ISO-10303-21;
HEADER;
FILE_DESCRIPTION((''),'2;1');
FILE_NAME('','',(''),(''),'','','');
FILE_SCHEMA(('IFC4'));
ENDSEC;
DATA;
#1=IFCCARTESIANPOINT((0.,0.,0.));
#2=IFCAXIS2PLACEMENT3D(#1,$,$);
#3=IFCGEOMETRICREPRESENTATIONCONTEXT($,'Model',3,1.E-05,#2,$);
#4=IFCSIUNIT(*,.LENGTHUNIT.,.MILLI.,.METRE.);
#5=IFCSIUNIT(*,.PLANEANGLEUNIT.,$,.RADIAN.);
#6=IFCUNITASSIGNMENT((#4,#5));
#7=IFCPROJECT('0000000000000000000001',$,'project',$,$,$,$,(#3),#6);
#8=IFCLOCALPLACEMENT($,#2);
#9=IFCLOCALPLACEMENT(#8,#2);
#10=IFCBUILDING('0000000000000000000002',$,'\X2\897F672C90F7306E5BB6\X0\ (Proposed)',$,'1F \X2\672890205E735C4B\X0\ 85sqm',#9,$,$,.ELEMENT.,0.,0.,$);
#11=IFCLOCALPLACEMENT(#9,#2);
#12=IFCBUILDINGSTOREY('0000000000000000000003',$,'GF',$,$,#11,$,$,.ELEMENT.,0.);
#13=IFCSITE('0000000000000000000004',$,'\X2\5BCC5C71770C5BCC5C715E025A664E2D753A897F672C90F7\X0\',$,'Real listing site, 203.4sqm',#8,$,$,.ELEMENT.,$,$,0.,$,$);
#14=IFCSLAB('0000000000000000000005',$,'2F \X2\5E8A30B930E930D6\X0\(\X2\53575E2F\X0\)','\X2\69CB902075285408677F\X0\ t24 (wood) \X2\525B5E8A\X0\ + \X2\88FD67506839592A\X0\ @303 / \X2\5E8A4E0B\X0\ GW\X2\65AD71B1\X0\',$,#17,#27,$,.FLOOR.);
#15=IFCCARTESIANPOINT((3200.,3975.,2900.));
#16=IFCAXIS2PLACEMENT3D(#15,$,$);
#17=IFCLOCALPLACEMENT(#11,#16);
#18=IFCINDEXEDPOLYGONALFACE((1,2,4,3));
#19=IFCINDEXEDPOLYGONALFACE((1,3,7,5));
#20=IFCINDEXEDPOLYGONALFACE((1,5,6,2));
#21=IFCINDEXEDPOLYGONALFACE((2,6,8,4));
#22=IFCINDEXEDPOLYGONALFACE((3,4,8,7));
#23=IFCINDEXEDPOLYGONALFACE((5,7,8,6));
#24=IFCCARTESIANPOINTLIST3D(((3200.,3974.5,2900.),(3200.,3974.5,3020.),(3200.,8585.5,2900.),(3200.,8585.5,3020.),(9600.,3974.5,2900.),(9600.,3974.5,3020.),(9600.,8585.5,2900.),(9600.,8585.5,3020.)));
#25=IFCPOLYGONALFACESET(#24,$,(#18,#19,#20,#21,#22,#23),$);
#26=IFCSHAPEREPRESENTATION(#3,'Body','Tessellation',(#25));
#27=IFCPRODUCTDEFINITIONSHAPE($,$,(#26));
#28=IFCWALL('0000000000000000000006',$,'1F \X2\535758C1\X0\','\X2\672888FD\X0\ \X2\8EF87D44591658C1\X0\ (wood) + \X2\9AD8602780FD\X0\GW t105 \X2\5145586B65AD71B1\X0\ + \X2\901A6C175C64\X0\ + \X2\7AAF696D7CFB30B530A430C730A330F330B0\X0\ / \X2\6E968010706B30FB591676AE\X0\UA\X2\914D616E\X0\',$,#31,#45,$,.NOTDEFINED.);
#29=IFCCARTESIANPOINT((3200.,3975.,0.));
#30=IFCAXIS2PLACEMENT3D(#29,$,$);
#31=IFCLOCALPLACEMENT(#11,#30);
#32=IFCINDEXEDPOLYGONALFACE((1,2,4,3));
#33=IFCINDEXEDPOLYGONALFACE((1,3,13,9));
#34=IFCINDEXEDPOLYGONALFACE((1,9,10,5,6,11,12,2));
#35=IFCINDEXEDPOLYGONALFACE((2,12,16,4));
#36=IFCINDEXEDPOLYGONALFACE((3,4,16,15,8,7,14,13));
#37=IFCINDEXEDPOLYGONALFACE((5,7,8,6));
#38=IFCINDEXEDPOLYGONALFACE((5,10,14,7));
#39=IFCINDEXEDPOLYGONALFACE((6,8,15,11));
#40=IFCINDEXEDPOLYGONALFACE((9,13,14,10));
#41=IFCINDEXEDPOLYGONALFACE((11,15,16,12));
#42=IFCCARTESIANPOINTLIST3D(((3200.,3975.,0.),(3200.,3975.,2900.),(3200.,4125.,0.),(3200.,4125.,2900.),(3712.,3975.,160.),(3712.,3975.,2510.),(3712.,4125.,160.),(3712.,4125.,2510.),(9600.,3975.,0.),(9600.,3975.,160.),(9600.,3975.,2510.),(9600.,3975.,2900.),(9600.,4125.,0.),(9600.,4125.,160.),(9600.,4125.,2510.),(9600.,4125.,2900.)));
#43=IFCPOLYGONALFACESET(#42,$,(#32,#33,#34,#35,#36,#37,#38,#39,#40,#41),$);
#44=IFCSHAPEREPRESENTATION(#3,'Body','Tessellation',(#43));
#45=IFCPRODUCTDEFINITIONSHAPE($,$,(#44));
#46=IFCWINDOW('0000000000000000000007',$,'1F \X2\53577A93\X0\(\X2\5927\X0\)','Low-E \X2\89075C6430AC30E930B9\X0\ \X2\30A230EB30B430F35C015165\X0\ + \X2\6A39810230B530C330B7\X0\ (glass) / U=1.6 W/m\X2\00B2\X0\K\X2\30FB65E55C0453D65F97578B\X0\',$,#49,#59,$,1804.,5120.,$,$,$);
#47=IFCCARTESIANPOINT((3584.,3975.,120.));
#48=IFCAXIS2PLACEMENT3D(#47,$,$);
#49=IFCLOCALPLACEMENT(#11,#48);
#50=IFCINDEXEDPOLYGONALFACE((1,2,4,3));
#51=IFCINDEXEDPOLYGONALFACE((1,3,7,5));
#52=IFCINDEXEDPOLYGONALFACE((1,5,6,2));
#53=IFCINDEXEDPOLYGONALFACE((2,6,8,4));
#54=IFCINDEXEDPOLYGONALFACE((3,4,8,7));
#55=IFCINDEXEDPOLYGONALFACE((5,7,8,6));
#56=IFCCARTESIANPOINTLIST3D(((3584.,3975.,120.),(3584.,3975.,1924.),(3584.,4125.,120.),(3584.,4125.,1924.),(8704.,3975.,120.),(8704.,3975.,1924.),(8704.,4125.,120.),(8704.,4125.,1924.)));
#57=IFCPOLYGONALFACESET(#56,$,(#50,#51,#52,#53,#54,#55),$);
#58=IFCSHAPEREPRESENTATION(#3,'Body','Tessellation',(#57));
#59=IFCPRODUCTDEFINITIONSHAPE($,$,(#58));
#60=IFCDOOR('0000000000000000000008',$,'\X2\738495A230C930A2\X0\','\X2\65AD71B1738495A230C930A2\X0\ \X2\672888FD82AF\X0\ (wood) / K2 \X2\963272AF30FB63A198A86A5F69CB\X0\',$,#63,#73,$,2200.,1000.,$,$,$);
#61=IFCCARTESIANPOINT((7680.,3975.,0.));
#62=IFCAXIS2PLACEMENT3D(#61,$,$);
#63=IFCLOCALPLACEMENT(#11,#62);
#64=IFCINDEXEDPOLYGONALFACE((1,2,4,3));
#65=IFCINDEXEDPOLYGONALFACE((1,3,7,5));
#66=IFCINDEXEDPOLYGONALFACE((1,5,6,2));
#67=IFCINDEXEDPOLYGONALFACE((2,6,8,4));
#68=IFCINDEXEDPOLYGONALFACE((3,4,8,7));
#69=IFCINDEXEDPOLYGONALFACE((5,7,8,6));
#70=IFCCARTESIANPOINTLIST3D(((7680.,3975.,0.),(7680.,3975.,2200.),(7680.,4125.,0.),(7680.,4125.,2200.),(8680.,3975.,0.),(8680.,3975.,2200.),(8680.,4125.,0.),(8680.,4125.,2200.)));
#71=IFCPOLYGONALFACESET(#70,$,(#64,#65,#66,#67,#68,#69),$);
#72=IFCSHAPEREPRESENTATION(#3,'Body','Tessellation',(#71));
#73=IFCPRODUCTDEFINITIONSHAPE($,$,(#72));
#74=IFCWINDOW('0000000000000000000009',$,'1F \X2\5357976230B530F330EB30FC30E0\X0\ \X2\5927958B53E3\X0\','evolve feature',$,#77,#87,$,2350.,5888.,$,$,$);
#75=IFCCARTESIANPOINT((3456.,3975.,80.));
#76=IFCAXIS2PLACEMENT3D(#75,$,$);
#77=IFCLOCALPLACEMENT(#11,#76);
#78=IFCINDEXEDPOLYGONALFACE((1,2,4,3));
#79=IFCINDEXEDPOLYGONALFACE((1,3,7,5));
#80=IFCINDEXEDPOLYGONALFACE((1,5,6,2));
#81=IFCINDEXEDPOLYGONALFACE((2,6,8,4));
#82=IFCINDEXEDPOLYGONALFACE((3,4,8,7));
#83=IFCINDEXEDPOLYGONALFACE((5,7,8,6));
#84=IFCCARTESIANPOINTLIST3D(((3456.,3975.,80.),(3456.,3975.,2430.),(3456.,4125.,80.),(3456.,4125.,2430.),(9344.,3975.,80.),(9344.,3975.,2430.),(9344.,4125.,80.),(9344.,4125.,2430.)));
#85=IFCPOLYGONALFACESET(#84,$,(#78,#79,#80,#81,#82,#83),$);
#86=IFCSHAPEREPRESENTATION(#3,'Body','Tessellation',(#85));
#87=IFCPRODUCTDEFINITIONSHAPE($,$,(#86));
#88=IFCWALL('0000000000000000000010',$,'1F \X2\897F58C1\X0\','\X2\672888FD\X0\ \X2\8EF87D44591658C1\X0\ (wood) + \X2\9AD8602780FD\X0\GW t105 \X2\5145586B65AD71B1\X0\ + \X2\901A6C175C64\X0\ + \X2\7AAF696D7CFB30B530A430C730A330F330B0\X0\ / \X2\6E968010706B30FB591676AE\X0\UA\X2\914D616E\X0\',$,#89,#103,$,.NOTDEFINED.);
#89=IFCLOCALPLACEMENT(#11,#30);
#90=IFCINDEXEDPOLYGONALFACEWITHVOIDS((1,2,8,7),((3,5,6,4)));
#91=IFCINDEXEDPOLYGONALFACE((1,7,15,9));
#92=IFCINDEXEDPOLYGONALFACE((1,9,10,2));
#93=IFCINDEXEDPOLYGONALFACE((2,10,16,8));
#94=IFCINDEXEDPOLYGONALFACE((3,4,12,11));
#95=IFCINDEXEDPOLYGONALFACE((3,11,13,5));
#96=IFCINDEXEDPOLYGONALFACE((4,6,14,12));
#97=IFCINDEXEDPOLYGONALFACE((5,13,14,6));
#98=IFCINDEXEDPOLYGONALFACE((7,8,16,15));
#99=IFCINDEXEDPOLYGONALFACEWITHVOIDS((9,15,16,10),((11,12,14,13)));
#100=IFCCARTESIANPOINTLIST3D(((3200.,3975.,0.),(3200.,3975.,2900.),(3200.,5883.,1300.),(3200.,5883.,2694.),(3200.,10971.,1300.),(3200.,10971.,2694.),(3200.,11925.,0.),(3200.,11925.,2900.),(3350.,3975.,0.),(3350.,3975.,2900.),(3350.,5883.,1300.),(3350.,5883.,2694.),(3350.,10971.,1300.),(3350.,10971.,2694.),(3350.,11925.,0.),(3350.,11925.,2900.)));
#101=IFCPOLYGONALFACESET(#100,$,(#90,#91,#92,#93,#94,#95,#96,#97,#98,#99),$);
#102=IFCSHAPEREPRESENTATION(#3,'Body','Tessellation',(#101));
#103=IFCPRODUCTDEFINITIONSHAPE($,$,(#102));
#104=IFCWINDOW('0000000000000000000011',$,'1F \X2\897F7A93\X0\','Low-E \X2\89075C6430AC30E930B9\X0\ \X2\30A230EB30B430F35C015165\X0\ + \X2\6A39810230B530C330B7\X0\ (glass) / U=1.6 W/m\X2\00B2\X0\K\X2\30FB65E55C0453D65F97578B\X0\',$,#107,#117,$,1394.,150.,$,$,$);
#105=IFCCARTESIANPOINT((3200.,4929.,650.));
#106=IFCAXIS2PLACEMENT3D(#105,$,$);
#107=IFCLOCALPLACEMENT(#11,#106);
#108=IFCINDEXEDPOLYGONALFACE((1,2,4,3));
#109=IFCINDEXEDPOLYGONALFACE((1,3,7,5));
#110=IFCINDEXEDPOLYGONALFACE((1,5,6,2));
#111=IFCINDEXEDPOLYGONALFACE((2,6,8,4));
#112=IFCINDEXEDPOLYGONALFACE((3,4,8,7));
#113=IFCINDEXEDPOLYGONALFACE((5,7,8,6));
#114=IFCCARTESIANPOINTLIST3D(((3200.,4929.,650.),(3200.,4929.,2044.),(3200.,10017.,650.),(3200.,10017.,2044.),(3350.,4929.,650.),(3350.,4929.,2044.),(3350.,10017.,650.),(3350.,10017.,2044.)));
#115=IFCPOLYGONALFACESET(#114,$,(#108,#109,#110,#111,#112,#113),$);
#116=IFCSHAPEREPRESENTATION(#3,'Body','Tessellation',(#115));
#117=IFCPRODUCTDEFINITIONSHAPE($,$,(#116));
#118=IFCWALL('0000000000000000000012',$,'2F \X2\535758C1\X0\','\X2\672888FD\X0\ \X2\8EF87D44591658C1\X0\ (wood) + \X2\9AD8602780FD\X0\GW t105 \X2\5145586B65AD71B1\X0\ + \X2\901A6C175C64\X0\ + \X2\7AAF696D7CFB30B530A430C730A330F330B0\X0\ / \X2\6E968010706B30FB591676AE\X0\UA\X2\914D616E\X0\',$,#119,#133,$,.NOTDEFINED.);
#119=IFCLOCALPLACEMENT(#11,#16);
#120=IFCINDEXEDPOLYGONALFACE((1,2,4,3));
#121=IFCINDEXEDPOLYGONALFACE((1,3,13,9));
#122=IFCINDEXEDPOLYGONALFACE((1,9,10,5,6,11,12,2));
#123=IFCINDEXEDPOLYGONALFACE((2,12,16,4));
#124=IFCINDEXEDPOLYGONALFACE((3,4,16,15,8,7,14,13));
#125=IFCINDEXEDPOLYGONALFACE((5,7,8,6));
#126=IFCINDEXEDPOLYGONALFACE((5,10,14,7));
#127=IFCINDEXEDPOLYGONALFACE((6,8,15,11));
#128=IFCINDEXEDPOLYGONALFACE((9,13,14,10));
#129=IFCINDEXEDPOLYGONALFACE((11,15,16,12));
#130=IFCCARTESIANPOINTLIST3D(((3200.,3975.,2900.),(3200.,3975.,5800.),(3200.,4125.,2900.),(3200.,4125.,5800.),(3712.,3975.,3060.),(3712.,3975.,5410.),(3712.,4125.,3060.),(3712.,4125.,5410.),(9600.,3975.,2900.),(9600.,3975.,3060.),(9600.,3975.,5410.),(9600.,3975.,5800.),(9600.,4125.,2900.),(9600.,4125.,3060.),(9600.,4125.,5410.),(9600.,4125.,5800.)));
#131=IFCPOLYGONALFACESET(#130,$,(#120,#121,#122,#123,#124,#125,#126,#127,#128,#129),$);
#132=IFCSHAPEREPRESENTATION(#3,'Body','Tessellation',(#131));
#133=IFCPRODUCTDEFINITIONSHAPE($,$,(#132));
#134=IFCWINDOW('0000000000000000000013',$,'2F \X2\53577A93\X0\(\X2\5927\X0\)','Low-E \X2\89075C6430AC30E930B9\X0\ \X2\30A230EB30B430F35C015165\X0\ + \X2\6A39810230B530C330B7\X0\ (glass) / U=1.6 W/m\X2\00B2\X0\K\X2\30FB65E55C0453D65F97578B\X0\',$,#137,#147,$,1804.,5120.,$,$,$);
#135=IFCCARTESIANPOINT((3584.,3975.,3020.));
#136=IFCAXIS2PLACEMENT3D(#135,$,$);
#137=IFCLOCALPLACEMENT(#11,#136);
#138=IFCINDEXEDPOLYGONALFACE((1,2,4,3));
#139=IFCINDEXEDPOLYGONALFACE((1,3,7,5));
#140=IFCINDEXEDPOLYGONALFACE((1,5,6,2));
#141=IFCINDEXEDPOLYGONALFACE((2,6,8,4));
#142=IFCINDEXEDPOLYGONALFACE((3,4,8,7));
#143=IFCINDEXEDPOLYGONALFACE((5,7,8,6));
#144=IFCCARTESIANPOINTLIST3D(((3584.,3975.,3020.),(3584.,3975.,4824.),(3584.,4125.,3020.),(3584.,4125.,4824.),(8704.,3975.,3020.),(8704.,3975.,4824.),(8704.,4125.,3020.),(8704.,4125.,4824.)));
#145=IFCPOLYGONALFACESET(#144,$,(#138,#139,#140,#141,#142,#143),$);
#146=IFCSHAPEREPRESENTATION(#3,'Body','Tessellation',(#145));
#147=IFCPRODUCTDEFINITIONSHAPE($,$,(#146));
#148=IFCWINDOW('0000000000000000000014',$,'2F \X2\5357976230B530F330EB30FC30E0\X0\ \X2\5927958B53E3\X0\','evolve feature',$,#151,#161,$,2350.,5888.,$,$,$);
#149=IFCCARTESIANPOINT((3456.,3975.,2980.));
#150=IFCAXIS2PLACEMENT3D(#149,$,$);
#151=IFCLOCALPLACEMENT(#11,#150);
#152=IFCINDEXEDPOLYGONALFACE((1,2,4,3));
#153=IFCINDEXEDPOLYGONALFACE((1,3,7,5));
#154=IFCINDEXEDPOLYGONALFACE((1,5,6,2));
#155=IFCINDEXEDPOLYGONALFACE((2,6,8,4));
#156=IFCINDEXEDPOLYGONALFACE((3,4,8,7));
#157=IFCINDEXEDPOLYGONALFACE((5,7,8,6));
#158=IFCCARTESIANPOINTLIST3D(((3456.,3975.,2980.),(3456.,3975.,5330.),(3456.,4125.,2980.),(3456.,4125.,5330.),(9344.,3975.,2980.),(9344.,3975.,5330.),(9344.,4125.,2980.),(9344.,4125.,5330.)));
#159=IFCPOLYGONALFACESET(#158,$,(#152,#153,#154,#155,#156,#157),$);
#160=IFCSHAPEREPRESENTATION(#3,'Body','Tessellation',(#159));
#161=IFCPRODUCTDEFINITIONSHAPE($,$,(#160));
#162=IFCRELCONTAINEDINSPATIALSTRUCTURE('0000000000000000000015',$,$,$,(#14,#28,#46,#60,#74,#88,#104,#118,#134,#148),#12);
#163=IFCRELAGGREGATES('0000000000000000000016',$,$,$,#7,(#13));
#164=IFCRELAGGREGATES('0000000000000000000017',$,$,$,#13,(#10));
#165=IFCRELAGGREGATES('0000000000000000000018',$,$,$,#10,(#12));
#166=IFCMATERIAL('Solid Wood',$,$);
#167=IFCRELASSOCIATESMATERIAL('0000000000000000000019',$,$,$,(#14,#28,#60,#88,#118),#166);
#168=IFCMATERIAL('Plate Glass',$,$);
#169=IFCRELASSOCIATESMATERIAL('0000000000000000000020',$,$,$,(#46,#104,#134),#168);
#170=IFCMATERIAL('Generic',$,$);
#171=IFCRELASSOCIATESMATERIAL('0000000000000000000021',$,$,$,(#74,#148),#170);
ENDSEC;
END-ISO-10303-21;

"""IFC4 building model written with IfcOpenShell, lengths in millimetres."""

from ifc_helpers import new_model, si_unit, frame, frame_2d, origin, place, context, project, spatial, rectangle, extrude, material, element, fill, save


model = new_model("IFC4")

# Units and contexts
model_context = context("Model", 3, precision=1e-05, world=origin())
ifc_project = project(units=[si_unit("LENGTHUNIT", "METRE", prefix="MILLI"), si_unit("PLANEANGLEUNIT", "RADIAN")], contexts=[model_context])

# Site, building, storey
site_placement = place(None, origin())
site = spatial("IfcSite", under=ifc_project, at=site_placement, Name="富山県富山市婦中町西本郷", ObjectType="Real listing site, 203.4sqm", CompositionType="ELEMENT", RefElevation=0.0)
building_placement = place(site_placement, origin())
building = spatial("IfcBuilding", under=site, at=building_placement, Name="西本郷の家 (Proposed)", ObjectType="1F 木造平屋 85sqm", CompositionType="ELEMENT", ElevationOfRefHeight=0.0, ElevationOfTerrain=0.0)
storey_placement = place(building_placement, origin())
storey = spatial("IfcBuildingStorey", under=building, at=storey_placement, Name="GF", CompositionType="ELEMENT", Elevation=0.0)

# Slab
ifc_material_1 = material(Name="Solid Wood")
slab_1_placement = place(storey_placement, frame((3200.0, 3975.0, 2900.0)))
element("IfcSlab", 1, at=slab_1_placement, inside=storey, material=ifc_material_1, Name="2F 床スラブ(南帯)", Description="構造用合板 t24 (wood) 剛床 + 製材根太 @303 / 床下 GW断熱", PredefinedType="FLOOR", context=model_context, shape_type="SweptSolid", body=[
    extrude(rectangle(XDim=6400.0, YDim=4611.0, at=frame_2d((3200.0, 2305.0))), frame((3200.0, 3975.0, 2900.0)), (0.0, 0.0, 1.0), 120.0),
])
ifc_material_2 = material(Name="Generic")

# Wall, openings, windows, door
wall_1_placement = place(storey_placement, frame((3200.0, 3975.0, 0.0)))
wall_1 = element("IfcWall", 2, at=wall_1_placement, inside=storey, material=ifc_material_1, Name="1F 南壁", Description="木製 軸組外壁 (wood) + 高性能GW t105 充填断熱 + 通気層 + 窯業系サイディング / 準耐火・外皮UA配慮", PredefinedType="NOTDEFINED", context=model_context, shape_type="SweptSolid", body=[
    extrude(rectangle(XDim=6400.0, YDim=150.0, at=frame_2d((3200.0, 75.0))), frame((3200.0, 3975.0, 0.0)), (0.0, 0.0, 1.0), 2900.0),
])
opening_1_placement = place(storey_placement, frame((3584.0, 3975.0, 120.0)))
opening_1 = element("IfcOpeningElement", 3, at=opening_1_placement, cuts=wall_1, PredefinedType="NOTDEFINED", context=model_context, shape_type="SweptSolid", body=[
    extrude(rectangle(XDim=5120.0, YDim=150.0, at=frame_2d((2560.0, 75.0))), frame((3584.0, 3975.0, 120.0)), (0.0, 0.0, 1.0), 1804.0),
])
opening_2_placement = place(storey_placement, frame((7680.0, 3975.0, 0.0)))
opening_2 = element("IfcOpeningElement", 4, at=opening_2_placement, cuts=wall_1, PredefinedType="NOTDEFINED", context=model_context, shape_type="SweptSolid", body=[
    extrude(rectangle(XDim=1000.0, YDim=150.0, at=frame_2d((500.0, 75.0))), frame((7680.0, 3975.0, 0.0)), (0.0, 0.0, 1.0), 2200.0),
])
opening_3_placement = place(storey_placement, frame((3456.0, 3975.0, 80.0)))
opening_3 = element("IfcOpeningElement", 5, at=opening_3_placement, cuts=wall_1, PredefinedType="NOTDEFINED", context=model_context, shape_type="SweptSolid", body=[
    extrude(rectangle(XDim=5888.0, YDim=150.0, at=frame_2d((2944.0, 75.0))), frame((3456.0, 3975.0, 80.0)), (0.0, 0.0, 1.0), 2350.0),
])
ifc_material_3 = material(Name="Plate Glass")
window_1_placement = place(storey_placement, frame((3584.0, 3975.0, 120.0)))
window_1 = element("IfcWindow", 6, at=window_1_placement, inside=storey, material=ifc_material_3, Name="1F 南窓(大)", Description="Low-E 複層ガラス アルゴン封入 + 樹脂サッシ (glass) / U=1.6 W/m²K・日射取得型", OverallHeight=1804.0, OverallWidth=5120.0, context=model_context, shape_type="SweptSolid", body=[
    extrude(rectangle(XDim=5120.0, YDim=150.0, at=frame_2d((2560.0, 75.0))), frame((3584.0, 3975.0, 120.0)), (0.0, 0.0, 1.0), 1804.0),
])
fill(opening_1, window_1)
door_placement = place(storey_placement, frame((7680.0, 3975.0, 0.0)))
door = element("IfcDoor", 7, at=door_placement, inside=storey, material=ifc_material_1, Name="玄関ドア", Description="断熱玄関ドア 木製芯 (wood) / K2 防犯・採風機構", OverallHeight=2200.0, OverallWidth=1000.0, context=model_context, shape_type="SweptSolid", body=[
    extrude(rectangle(XDim=1000.0, YDim=150.0, at=frame_2d((500.0, 75.0))), frame((7680.0, 3975.0, 0.0)), (0.0, 0.0, 1.0), 2200.0),
])
fill(opening_2, door)
window_2_placement = place(storey_placement, frame((3456.0, 3975.0, 80.0)))
window_2 = element("IfcWindow", 8, at=window_2_placement, inside=storey, material=ifc_material_2, Name="1F 南面サンルーム 大開口", Description="evolve feature", OverallHeight=2350.0, OverallWidth=5888.0, context=model_context, shape_type="SweptSolid", body=[
    extrude(rectangle(XDim=5888.0, YDim=150.0, at=frame_2d((2944.0, 75.0))), frame((3456.0, 3975.0, 80.0)), (0.0, 0.0, 1.0), 2350.0),
])
fill(opening_3, window_2)

# Wall, opening, window
wall_2_placement = place(storey_placement, frame((3200.0, 3975.0, 0.0)))
wall_2 = element("IfcWall", 9, at=wall_2_placement, inside=storey, material=ifc_material_1, Name="1F 西壁", Description="木製 軸組外壁 (wood) + 高性能GW t105 充填断熱 + 通気層 + 窯業系サイディング / 準耐火・外皮UA配慮", PredefinedType="NOTDEFINED", context=model_context, shape_type="SweptSolid", body=[
    extrude(rectangle(XDim=150.0, YDim=7950.0, at=frame_2d((75.0, 3975.0))), frame((3200.0, 3975.0, 0.0)), (0.0, 0.0, 1.0), 2900.0),
])
opening_4_placement = place(storey_placement, frame((3200.0, 4929.0, 650.0)))
opening_4 = element("IfcOpeningElement", 10, at=opening_4_placement, cuts=wall_2, PredefinedType="NOTDEFINED", context=model_context, shape_type="SweptSolid", body=[
    extrude(rectangle(XDim=150.0, YDim=5088.0, at=frame_2d((75.0, 2544.0))), frame((3200.0, 4929.0, 650.0)), (0.0, 0.0, 1.0), 1394.0),
])
window_3_placement = place(storey_placement, frame((3200.0, 4929.0, 650.0)))
window_3 = element("IfcWindow", 11, at=window_3_placement, inside=storey, material=ifc_material_3, Name="1F 西窓", Description="Low-E 複層ガラス アルゴン封入 + 樹脂サッシ (glass) / U=1.6 W/m²K・日射取得型", OverallHeight=1394.0, OverallWidth=150.0, context=model_context, shape_type="SweptSolid", body=[
    extrude(rectangle(XDim=150.0, YDim=5088.0, at=frame_2d((75.0, 2544.0))), frame((3200.0, 4929.0, 650.0)), (0.0, 0.0, 1.0), 1394.0),
])
fill(opening_4, window_3)

# Wall, openings, windows
wall_3_placement = place(storey_placement, frame((3200.0, 3975.0, 2900.0)))
wall_3 = element("IfcWall", 12, at=wall_3_placement, inside=storey, material=ifc_material_1, Name="2F 南壁", Description="木製 軸組外壁 (wood) + 高性能GW t105 充填断熱 + 通気層 + 窯業系サイディング / 準耐火・外皮UA配慮", PredefinedType="NOTDEFINED", context=model_context, shape_type="SweptSolid", body=[
    extrude(rectangle(XDim=6400.0, YDim=150.0, at=frame_2d((3200.0, 75.0))), frame((3200.0, 3975.0, 2900.0)), (0.0, 0.0, 1.0), 2900.0),
])
opening_5_placement = place(storey_placement, frame((3584.0, 3975.0, 3020.0)))
opening_5 = element("IfcOpeningElement", 13, at=opening_5_placement, cuts=wall_3, PredefinedType="NOTDEFINED", context=model_context, shape_type="SweptSolid", body=[
    extrude(rectangle(XDim=5120.0, YDim=150.0, at=frame_2d((2560.0, 75.0))), frame((3584.0, 3975.0, 3020.0)), (0.0, 0.0, 1.0), 1804.0),
])
opening_6_placement = place(storey_placement, frame((3456.0, 3975.0, 2980.0)))
opening_6 = element("IfcOpeningElement", 14, at=opening_6_placement, cuts=wall_3, PredefinedType="NOTDEFINED", context=model_context, shape_type="SweptSolid", body=[
    extrude(rectangle(XDim=5888.0, YDim=150.0, at=frame_2d((2944.0, 75.0))), frame((3456.0, 3975.0, 2980.0)), (0.0, 0.0, 1.0), 2350.0),
])
window_4_placement = place(storey_placement, frame((3584.0, 3975.0, 3020.0)))
window_4 = element("IfcWindow", 15, at=window_4_placement, inside=storey, material=ifc_material_3, Name="2F 南窓(大)", Description="Low-E 複層ガラス アルゴン封入 + 樹脂サッシ (glass) / U=1.6 W/m²K・日射取得型", OverallHeight=1804.0, OverallWidth=5120.0, context=model_context, shape_type="SweptSolid", body=[
    extrude(rectangle(XDim=5120.0, YDim=150.0, at=frame_2d((2560.0, 75.0))), frame((3584.0, 3975.0, 3020.0)), (0.0, 0.0, 1.0), 1804.0),
])
fill(opening_5, window_4)
window_5_placement = place(storey_placement, frame((3456.0, 3975.0, 2980.0)))
window_5 = element("IfcWindow", 16, at=window_5_placement, inside=storey, material=ifc_material_2, Name="2F 南面サンルーム 大開口", Description="evolve feature", OverallHeight=2350.0, OverallWidth=5888.0, context=model_context, shape_type="SweptSolid", body=[
    extrude(rectangle(XDim=5888.0, YDim=150.0, at=frame_2d((2944.0, 75.0))), frame((3456.0, 3975.0, 2980.0)), (0.0, 0.0, 1.0), 2350.0),
])
fill(opening_6, window_5)

save(model, "model.ifc")
